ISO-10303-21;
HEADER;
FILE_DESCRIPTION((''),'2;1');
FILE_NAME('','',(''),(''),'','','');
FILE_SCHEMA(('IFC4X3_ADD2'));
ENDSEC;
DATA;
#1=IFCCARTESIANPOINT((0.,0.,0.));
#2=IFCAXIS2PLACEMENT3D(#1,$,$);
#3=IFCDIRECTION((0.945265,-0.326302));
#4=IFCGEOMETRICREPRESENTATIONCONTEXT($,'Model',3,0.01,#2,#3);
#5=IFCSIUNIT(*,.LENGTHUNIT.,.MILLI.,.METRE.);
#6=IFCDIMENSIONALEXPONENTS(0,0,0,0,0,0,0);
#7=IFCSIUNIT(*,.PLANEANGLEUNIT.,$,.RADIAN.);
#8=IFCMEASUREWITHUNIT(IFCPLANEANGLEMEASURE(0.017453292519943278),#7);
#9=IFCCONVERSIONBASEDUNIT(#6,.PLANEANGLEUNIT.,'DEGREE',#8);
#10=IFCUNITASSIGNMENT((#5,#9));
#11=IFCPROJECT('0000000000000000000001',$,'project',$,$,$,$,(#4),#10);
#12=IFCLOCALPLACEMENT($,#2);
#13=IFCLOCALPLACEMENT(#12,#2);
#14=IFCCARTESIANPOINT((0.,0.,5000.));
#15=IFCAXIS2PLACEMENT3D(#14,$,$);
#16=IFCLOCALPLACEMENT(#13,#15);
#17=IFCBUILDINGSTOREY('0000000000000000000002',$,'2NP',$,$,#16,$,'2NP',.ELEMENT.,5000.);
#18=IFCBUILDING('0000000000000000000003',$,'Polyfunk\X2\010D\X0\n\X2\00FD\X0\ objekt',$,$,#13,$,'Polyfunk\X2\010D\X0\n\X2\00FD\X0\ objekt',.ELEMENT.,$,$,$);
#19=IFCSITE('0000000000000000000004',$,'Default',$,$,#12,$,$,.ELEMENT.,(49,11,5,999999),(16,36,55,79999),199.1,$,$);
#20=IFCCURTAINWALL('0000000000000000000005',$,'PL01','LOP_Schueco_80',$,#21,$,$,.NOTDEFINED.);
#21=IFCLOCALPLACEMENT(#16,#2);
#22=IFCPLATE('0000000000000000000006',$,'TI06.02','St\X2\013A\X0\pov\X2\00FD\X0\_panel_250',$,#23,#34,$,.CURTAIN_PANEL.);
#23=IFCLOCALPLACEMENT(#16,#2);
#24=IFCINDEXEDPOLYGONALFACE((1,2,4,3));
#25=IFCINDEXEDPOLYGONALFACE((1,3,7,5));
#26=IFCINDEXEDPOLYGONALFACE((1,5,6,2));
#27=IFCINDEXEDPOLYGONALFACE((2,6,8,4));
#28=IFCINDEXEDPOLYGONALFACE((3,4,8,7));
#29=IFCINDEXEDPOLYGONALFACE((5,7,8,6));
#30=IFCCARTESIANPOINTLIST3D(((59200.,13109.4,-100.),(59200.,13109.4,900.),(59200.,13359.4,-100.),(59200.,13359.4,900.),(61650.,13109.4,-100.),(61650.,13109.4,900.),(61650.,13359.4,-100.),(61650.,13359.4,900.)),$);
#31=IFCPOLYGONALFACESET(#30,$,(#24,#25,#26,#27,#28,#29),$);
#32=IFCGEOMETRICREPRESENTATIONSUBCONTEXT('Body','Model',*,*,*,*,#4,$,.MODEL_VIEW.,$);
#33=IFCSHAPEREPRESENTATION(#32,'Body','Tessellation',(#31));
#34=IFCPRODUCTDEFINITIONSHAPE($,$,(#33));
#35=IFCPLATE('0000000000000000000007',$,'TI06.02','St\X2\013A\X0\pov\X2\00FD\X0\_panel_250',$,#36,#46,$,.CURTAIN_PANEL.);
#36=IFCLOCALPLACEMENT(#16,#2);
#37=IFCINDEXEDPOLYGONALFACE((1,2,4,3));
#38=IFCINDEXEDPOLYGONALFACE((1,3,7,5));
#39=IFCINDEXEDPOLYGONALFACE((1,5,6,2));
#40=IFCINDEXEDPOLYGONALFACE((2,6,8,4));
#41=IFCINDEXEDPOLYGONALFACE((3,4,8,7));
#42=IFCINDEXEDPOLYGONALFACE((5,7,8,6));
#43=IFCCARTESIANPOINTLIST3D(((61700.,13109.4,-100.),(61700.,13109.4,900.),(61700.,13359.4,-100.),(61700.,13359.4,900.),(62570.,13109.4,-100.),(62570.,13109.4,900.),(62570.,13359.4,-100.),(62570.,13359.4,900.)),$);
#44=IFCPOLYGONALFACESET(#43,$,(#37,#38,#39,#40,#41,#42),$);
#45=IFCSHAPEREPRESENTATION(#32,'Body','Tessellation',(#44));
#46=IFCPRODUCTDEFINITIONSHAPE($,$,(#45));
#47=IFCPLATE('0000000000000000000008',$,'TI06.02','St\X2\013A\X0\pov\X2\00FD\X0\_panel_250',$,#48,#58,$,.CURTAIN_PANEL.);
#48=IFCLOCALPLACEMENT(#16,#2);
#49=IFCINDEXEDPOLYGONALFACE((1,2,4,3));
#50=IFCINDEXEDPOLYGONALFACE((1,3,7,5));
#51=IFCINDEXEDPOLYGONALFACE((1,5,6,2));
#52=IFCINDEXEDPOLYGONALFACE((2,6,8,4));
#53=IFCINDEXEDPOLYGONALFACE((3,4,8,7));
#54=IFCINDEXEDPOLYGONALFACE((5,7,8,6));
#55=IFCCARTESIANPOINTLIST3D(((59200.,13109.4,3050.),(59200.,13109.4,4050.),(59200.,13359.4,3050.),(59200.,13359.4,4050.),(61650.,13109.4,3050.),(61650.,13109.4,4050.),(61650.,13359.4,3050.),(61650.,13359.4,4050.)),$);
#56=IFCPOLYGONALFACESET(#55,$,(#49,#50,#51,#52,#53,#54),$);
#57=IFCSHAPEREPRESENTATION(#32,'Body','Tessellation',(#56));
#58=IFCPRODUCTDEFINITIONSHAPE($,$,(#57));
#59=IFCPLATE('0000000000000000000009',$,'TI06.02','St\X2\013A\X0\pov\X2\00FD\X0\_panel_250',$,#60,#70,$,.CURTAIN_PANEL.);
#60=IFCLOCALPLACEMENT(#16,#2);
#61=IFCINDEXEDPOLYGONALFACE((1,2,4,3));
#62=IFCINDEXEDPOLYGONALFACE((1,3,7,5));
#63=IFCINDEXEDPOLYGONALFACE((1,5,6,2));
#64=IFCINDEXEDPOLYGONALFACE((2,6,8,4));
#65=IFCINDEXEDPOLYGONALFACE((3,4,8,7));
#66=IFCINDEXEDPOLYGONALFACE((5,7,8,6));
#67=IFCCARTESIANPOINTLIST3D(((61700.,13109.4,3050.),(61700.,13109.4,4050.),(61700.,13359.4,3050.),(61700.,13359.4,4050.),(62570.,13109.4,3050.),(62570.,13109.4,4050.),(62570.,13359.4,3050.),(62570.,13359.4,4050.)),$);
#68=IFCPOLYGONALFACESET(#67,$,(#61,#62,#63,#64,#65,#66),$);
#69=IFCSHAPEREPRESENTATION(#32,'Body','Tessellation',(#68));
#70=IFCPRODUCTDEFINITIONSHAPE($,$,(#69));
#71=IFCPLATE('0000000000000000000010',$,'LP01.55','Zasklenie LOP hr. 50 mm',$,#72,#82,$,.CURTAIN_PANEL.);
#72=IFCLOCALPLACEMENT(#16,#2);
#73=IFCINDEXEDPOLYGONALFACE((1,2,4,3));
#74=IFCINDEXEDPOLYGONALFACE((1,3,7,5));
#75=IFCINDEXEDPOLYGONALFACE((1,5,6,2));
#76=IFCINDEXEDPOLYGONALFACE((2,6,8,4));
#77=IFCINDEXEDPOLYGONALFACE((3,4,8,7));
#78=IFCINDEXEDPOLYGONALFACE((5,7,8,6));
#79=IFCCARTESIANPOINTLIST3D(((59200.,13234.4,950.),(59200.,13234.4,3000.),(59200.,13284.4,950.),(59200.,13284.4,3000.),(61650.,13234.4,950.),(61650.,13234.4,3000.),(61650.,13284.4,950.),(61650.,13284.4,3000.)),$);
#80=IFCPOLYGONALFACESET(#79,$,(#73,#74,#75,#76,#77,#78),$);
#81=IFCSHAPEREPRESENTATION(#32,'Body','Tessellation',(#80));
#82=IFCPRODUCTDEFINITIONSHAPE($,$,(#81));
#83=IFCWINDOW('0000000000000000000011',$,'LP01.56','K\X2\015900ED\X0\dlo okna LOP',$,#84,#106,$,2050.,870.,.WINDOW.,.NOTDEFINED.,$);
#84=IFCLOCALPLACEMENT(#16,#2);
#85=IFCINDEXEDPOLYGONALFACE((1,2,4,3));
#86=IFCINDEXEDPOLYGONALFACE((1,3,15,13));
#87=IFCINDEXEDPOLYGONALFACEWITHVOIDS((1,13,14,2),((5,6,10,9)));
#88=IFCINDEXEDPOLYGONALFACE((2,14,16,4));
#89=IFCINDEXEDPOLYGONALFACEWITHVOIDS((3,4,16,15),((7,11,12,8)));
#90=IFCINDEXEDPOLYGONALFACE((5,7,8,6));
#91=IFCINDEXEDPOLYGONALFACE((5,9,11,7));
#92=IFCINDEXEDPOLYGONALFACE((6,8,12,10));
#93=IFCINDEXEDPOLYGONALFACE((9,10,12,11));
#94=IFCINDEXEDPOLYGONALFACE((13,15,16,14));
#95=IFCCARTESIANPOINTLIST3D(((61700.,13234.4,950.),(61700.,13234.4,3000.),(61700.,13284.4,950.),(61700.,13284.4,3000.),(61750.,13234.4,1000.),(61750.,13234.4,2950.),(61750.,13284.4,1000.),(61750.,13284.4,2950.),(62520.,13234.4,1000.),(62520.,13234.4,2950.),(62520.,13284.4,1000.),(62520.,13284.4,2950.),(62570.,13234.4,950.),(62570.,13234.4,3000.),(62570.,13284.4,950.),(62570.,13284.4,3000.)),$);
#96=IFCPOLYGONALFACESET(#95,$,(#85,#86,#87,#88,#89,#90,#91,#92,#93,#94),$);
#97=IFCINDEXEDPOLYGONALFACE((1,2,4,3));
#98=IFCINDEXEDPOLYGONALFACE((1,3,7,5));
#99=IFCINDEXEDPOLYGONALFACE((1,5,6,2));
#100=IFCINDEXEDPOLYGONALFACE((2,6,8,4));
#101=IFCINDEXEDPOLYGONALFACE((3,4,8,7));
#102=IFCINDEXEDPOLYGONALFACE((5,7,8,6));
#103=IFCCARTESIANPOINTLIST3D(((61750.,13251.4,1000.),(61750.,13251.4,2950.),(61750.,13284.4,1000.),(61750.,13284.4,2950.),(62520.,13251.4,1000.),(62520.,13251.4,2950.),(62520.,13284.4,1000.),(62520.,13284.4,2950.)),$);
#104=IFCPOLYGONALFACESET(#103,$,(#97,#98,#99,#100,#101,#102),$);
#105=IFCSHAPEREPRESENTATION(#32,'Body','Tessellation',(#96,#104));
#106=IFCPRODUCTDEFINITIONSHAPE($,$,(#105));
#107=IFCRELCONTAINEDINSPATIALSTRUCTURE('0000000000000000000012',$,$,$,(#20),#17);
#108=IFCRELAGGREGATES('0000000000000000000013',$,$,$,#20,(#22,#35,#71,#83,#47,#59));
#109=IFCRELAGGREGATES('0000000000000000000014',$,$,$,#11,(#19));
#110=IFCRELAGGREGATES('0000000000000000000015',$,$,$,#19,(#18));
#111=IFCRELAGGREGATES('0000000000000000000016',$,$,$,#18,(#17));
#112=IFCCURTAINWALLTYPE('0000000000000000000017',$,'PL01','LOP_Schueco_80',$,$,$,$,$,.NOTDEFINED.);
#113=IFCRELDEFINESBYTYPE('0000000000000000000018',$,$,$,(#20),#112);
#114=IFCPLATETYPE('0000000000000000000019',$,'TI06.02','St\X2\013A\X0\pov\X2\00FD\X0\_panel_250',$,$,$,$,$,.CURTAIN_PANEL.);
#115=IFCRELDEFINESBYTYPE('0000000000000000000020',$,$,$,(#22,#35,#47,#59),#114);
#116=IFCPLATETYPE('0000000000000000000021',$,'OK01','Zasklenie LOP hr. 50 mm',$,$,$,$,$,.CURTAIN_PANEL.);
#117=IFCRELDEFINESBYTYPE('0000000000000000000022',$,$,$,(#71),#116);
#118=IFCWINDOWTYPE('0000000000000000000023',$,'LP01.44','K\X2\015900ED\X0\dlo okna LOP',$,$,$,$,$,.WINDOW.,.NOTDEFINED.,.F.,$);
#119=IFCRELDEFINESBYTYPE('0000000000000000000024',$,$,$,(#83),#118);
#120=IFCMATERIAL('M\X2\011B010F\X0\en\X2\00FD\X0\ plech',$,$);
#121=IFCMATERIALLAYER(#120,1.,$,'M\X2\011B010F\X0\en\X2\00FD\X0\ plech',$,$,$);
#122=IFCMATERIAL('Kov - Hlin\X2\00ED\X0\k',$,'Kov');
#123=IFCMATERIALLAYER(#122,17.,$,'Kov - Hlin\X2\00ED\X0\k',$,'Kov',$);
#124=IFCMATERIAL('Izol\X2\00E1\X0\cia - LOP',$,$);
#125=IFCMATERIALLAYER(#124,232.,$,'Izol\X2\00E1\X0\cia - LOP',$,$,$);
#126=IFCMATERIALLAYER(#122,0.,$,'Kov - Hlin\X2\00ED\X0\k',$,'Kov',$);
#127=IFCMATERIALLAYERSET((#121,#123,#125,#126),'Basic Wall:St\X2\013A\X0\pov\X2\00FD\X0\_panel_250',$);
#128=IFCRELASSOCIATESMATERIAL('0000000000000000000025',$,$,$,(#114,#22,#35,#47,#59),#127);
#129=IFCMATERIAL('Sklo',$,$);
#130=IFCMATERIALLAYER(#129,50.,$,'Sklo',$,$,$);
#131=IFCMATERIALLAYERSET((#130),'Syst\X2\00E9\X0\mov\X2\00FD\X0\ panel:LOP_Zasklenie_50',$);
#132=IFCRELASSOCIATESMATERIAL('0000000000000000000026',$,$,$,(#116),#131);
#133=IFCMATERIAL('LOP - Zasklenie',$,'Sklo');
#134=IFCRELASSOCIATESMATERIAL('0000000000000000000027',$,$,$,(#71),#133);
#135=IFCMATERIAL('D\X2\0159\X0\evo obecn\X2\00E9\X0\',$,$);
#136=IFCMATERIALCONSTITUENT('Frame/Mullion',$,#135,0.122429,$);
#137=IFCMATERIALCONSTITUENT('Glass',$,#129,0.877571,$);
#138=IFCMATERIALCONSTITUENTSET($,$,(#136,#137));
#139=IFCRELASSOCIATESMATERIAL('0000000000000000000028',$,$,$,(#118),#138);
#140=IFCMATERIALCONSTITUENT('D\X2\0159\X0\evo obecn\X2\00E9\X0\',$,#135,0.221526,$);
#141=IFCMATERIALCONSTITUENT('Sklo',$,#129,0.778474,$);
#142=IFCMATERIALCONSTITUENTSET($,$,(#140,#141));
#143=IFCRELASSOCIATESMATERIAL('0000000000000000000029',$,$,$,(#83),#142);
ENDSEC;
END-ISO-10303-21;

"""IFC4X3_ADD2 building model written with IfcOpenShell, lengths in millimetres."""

from ifc_helpers import new_model, entity, si_unit, converted_unit, direction, frame, frame_2d, origin, origin_2d_with_axis, place, context, subcontext, project, spatial, polyline, rectangle, outline, extrude, source, transform, mapped, material, layer, layer_set, layer_usage, constituent, constituent_set, type_object, type_shapes, element, aggregate, save


model = new_model("IFC4X3_ADD2")

# Units and contexts
model_context = context("Model", 3, precision=0.01, world=origin(), true_north=direction((0.945265, -0.326302)))
body_context = subcontext(model_context, "Body", "Model", "MODEL_VIEW")
ifc_project = project(units=[si_unit("LENGTHUNIT", "METRE", prefix="MILLI"), converted_unit("PLANEANGLEUNIT", "DEGREE", entity("IfcPlaneAngleMeasure", 0.017453292519943278), si_unit("PLANEANGLEUNIT", "RADIAN"), dimensions=[0, 0, 0, 0, 0, 0, 0])], contexts=[model_context])

# Site, building, storey
site_placement = place(None, origin())
site = spatial("IfcSite", under=ifc_project, at=site_placement, Name="Default", CompositionType="ELEMENT", RefLatitude=(49, 11, 5, 999999), RefLongitude=(16, 36, 55, 79999), RefElevation=199.1)
building_placement = place(site_placement, origin())
building = spatial("IfcBuilding", under=site, at=building_placement, Name="Polyfunkčný objekt", LongName="Polyfunkčný objekt", CompositionType="ELEMENT")
storey_placement = place(building_placement, frame((0.0, 0.0, 5000.0)))
storey = spatial("IfcBuildingStorey", under=building, at=storey_placement, Name="2NP", LongName="2NP", CompositionType="ELEMENT", Elevation=5000.0)

# Curtain wall, plates, window
curtain_wall_type = type_object("IfcCurtainWallType", Name="PL01", Description="LOP_Schueco_80", PredefinedType="NOTDEFINED")
curtain_wall_placement = place(storey_placement, frame((0.0, 0.0, -5000.0)))
curtain_wall = element("IfcCurtainWall", 1, at=curtain_wall_placement, inside=storey, type_object=curtain_wall_type, Name="PL01", Description="LOP_Schueco_80", PredefinedType="NOTDEFINED")
ifc_material_1 = material(Name="Měďený plech")
ifc_layer_1 = layer(ifc_material_1, 1.0, Name="Měďený plech")
ifc_material_2 = material(Name="Kov - Hliník", Category="Kov")
ifc_layer_2 = layer(ifc_material_2, 17.0, Name="Kov - Hliník", Category="Kov")
ifc_material_3 = material(Name="Izolácia - LOP")
ifc_layer_3 = layer(ifc_material_3, 232.0, Name="Izolácia - LOP")
ifc_layer_4 = layer(ifc_material_2, 0.0, Name="Kov - Hliník", Category="Kov")
ifc_layer_set_1 = layer_set([ifc_layer_1, ifc_layer_2, ifc_layer_3, ifc_layer_4], Name="Basic Wall:Stĺpový_panel_250")
ifc_layer_usage_1 = layer_usage(ifc_layer_set_1, "AXIS2", "NEGATIVE", 125.0)
plate_type_1 = type_object("IfcPlateType", Name="TI06.02", Description="Stĺpový_panel_250", PredefinedType="CURTAIN_PANEL", material=ifc_layer_set_1)
plate_1_placement = place(storey_placement, frame((59200.0, 13234.4, -100.0)))
plate_1 = element("IfcPlate", 2, at=plate_1_placement, type_object=plate_type_1, material=ifc_layer_usage_1, Name="TI06.02", Description="Stĺpový_panel_250", PredefinedType="CURTAIN_PANEL", context=body_context, shape_type="SweptSolid", body=[
    extrude(rectangle(XDim=250.0, YDim=2450.0, at=frame_2d((0.0, 0.0), x_axis=(1.0, 0.0))), frame((1225.0, 0.0, 0.0), z_axis=(0.0, 0.0, 1.0), x_axis=(0.0, 1.0, 0.0)), (0.0, 0.0, 1.0), 1000.0),
])
ifc_layer_usage_2 = layer_usage(ifc_layer_set_1, "AXIS2", "NEGATIVE", 125.0)
plate_2_placement = place(storey_placement, frame((61700.0, 13234.4, -100.0)))
plate_2 = element("IfcPlate", 3, at=plate_2_placement, type_object=plate_type_1, material=ifc_layer_usage_2, Name="TI06.02", Description="Stĺpový_panel_250", PredefinedType="CURTAIN_PANEL", context=body_context, shape_type="SweptSolid", body=[
    extrude(rectangle(XDim=250.0, YDim=870.0, at=frame_2d((0.0, 0.0), x_axis=(1.0, 0.0))), frame((435.0, 0.0, 0.0), z_axis=(0.0, 0.0, 1.0), x_axis=(0.0, 1.0, 0.0)), (0.0, 0.0, 1.0), 1000.0),
])
ifc_layer_usage_3 = layer_usage(ifc_layer_set_1, "AXIS2", "NEGATIVE", 125.0)
plate_3_placement = place(storey_placement, frame((59200.0, 13234.4, 3050.0)))
plate_3 = element("IfcPlate", 4, at=plate_3_placement, type_object=plate_type_1, material=ifc_layer_usage_3, Name="TI06.02", Description="Stĺpový_panel_250", PredefinedType="CURTAIN_PANEL", context=body_context, shape_type="SweptSolid", body=[
    extrude(rectangle(XDim=250.0, YDim=2450.0, at=frame_2d((0.0, 0.0), x_axis=(1.0, 0.0))), frame((1225.0, 0.0, 0.0), z_axis=(0.0, 0.0, 1.0), x_axis=(0.0, 1.0, 0.0)), (0.0, 0.0, 1.0), 1000.0),
])
ifc_layer_usage_4 = layer_usage(ifc_layer_set_1, "AXIS2", "NEGATIVE", 125.0)
plate_4_placement = place(storey_placement, frame((61700.0, 13234.4, 3050.0)))
plate_4 = element("IfcPlate", 5, at=plate_4_placement, type_object=plate_type_1, material=ifc_layer_usage_4, Name="TI06.02", Description="Stĺpový_panel_250", PredefinedType="CURTAIN_PANEL", context=body_context, shape_type="SweptSolid", body=[
    extrude(rectangle(XDim=250.0, YDim=870.0, at=frame_2d((0.0, 0.0), x_axis=(1.0, 0.0))), frame((435.0, 0.0, 0.0), z_axis=(0.0, 0.0, 1.0), x_axis=(0.0, 1.0, 0.0)), (0.0, 0.0, 1.0), 1000.0),
])
ifc_material_4 = material(Name="LOP - Zasklenie", Category="Sklo")
ifc_material_5 = material(Name="Sklo")
ifc_layer_5 = layer(ifc_material_5, 50.0, Name="Sklo")
ifc_layer_set_2 = layer_set([ifc_layer_5], Name="Systémový panel:LOP_Zasklenie_50")
plate_type_2 = type_object("IfcPlateType", Name="OK01", Description="Zasklenie LOP hr. 50 mm", PredefinedType="CURTAIN_PANEL", material=ifc_layer_set_2)
shared_shape_1 = source(origin(), body_context, "Body", "SweptSolid", [
    extrude(rectangle(XDim=50.0, YDim=2450.0, at=origin_2d_with_axis()), frame((0.0, 25.0, 0.0), z_axis=(0.0, 0.0, 1.0), x_axis=(0.0, 1.0, 0.0)), (0.0, 0.0, 1.0), 2050.0),
])
type_shapes(plate_type_2, [shared_shape_1])
plate_5_placement = place(curtain_wall_placement, frame((60425.0, 13234.4, 5950.0)))
plate_5 = element("IfcPlate", 6, at=plate_5_placement, type_object=plate_type_2, material=ifc_material_4, Name="LP01.55", Description="Zasklenie LOP hr. 50 mm", PredefinedType="CURTAIN_PANEL", context=body_context, shape_type="MappedRepresentation", body=[
    mapped(shared_shape_1, transform((0.0, 0.0, 0.0), scale=1.0)),
])
ifc_material_6 = material(Name="Dřevo obecné")
ifc_constituent_1 = constituent(ifc_material_6, Name="Dřevo obecné", fraction=0.221526)
ifc_constituent_2 = constituent(ifc_material_5, Name="Sklo", fraction=0.778474)
ifc_constituent_set_1 = constituent_set(constituents=[ifc_constituent_1, ifc_constituent_2])
ifc_constituent_3 = constituent(ifc_material_6, Name="Frame/Mullion", fraction=0.122429)
ifc_constituent_4 = constituent(ifc_material_5, Name="Glass", fraction=0.877571)
ifc_constituent_set_2 = constituent_set(constituents=[ifc_constituent_3, ifc_constituent_4])
window_type = type_object("IfcWindowType", Name="LP01.44", Description="Křídlo okna LOP", ParameterTakesPrecedence=False, PartitioningType="NOTDEFINED", PredefinedType="WINDOW", material=ifc_constituent_set_2)
shared_shape_2 = source(origin(), body_context, "Body", "SweptSolid", [
    extrude(outline(polyline([(-1025.0, -435.0), (1025.0, -435.0), (1025.0, 435.0), (-1025.0, 435.0), (-1025.0, -435.0)]), holes=[polyline([(-975.0, -385.0), (-975.0, 385.0), (975.0, 385.0), (975.0, -385.0), (-975.0, -385.0)])]), frame((0.0, 0.0, 1025.0), z_axis=(0.0, 1.0, 0.0), x_axis=(0.0, 0.0, -1.0)), (0.0, 0.0, 1.0), 50.0),
    extrude(rectangle(XDim=33.0, YDim=770.0, at=origin_2d_with_axis()), frame((0.0, 33.5, 50.0), z_axis=(0.0, 0.0, 1.0), x_axis=(0.0, -1.0, 0.0)), (0.0, 0.0, 1.0), 1950.0),
])
type_shapes(window_type, [shared_shape_2])
window_placement = place(curtain_wall_placement, frame((62135.0, 13234.4, 5950.0)))
window = element("IfcWindow", 7, at=window_placement, type_object=window_type, material=ifc_constituent_set_1, Name="LP01.56", Description="Křídlo okna LOP", OverallHeight=2050.0, OverallWidth=870.0, PartitioningType="NOTDEFINED", PredefinedType="WINDOW", context=body_context, shape_type="MappedRepresentation", body=[
    mapped(shared_shape_2, transform((0.0, 0.0, 0.0), scale=1.0)),
])
aggregate(curtain_wall, [plate_1, plate_2, plate_5, window, plate_3, plate_4])

save(model, "model.ifc")
